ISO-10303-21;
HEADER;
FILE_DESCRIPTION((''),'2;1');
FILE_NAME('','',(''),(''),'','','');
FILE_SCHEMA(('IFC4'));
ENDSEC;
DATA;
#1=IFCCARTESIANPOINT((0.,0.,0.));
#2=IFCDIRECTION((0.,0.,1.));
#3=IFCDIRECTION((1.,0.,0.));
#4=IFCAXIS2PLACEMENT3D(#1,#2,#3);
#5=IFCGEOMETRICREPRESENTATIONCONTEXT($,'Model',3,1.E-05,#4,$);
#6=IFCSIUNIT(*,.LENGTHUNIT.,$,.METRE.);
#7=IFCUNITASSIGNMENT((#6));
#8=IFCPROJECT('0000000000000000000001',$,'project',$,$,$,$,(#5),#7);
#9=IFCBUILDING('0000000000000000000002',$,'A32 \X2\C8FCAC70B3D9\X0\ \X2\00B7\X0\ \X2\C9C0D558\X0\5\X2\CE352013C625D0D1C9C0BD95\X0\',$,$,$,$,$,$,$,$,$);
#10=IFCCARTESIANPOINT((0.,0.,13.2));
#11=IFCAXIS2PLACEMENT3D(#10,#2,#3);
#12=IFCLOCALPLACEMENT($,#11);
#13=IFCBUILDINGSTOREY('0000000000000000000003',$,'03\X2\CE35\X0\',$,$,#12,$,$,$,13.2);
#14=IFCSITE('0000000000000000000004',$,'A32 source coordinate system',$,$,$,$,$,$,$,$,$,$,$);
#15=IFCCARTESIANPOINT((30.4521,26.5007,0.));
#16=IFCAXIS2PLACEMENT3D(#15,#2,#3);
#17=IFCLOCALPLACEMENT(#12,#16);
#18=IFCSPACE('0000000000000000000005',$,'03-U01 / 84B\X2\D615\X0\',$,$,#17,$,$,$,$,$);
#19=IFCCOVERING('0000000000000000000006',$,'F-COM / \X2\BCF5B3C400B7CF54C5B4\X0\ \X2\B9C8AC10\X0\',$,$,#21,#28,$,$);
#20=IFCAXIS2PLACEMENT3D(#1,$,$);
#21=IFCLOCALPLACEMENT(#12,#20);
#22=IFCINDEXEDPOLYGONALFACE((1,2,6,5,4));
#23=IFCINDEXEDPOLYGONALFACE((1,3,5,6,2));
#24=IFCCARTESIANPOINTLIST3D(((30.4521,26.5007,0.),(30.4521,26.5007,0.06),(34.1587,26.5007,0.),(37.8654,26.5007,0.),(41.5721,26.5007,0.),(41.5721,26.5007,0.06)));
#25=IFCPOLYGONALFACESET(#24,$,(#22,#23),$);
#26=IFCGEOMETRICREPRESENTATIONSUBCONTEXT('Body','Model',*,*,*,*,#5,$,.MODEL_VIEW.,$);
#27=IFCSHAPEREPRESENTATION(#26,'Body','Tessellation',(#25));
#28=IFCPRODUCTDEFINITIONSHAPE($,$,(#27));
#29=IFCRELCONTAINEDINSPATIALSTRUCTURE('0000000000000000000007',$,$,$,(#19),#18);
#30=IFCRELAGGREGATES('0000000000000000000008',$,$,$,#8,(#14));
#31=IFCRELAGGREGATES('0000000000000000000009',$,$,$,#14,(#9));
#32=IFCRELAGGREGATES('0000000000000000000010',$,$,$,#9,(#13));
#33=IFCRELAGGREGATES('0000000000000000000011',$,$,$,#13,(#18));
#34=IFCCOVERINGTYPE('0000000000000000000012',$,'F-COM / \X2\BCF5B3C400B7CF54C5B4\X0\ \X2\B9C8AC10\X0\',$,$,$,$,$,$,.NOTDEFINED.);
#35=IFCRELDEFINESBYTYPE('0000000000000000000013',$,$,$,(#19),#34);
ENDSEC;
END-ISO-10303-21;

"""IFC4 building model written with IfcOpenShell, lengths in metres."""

from ifc_helpers import new_model, si_unit, frame, origin, origin_with_axes, place, context, subcontext, project, spatial, polyline, outline, extrude, source, transform, mapped, type_object, type_shapes, element, save


model = new_model("IFC4")

# Units and contexts
model_context = context("Model", 3, precision=1e-05, world=origin_with_axes())
body_context = subcontext(model_context, "Body", "Model", "MODEL_VIEW")
ifc_project = project(units=[si_unit("LENGTHUNIT", "METRE")], contexts=[model_context])

# Site, building, storey, space
storey_placement = place(None, frame((0.0, 0.0, 13.2), z_axis=(0.0, 0.0, 1.0), x_axis=(1.0, 0.0, 0.0)))
space_placement = place(storey_placement, frame((30.4521, 26.5007, 0.0), z_axis=(0.0, 0.0, 1.0), x_axis=(1.0, 0.0, 0.0)))
site = spatial("IfcSite", under=ifc_project, Name="A32 source coordinate system")
building = spatial("IfcBuilding", under=site, Name="A32 주거동 · 지하5층–옥탑지붕")
storey = spatial("IfcBuildingStorey", under=building, at=storey_placement, Name="03층", Elevation=13.2)
space = spatial("IfcSpace", under=storey, at=space_placement, Name="03-U01 / 84B형")

# Covering
covering_type_1 = type_object("IfcCoveringType", Name="F-COM / 복도·코어 마감", PredefinedType="NOTDEFINED")
shared_shape_1 = source(origin(), body_context, "Body", "SweptSolid", [
    extrude(outline(polyline([(11.12, 0.0), (11.12, 0.0), (0.0, 0.0), (0.0, 0.0), (11.12, 0.0)])), origin(), (0.0, 0.0, 1.0), 0.06),
])
type_shapes(covering_type_1, [shared_shape_1])
covering_1_placement = place(space_placement, origin_with_axes())
element("IfcCovering", 1, at=covering_1_placement, inside=space, type_object=covering_type_1, Name="F-COM / 복도·코어 마감", context=body_context, shape_type="MappedRepresentation", body=[
    mapped(shared_shape_1, transform((0.0, 0.0, 0.0), scale=1.0)),
])

save(model, "model.ifc")
